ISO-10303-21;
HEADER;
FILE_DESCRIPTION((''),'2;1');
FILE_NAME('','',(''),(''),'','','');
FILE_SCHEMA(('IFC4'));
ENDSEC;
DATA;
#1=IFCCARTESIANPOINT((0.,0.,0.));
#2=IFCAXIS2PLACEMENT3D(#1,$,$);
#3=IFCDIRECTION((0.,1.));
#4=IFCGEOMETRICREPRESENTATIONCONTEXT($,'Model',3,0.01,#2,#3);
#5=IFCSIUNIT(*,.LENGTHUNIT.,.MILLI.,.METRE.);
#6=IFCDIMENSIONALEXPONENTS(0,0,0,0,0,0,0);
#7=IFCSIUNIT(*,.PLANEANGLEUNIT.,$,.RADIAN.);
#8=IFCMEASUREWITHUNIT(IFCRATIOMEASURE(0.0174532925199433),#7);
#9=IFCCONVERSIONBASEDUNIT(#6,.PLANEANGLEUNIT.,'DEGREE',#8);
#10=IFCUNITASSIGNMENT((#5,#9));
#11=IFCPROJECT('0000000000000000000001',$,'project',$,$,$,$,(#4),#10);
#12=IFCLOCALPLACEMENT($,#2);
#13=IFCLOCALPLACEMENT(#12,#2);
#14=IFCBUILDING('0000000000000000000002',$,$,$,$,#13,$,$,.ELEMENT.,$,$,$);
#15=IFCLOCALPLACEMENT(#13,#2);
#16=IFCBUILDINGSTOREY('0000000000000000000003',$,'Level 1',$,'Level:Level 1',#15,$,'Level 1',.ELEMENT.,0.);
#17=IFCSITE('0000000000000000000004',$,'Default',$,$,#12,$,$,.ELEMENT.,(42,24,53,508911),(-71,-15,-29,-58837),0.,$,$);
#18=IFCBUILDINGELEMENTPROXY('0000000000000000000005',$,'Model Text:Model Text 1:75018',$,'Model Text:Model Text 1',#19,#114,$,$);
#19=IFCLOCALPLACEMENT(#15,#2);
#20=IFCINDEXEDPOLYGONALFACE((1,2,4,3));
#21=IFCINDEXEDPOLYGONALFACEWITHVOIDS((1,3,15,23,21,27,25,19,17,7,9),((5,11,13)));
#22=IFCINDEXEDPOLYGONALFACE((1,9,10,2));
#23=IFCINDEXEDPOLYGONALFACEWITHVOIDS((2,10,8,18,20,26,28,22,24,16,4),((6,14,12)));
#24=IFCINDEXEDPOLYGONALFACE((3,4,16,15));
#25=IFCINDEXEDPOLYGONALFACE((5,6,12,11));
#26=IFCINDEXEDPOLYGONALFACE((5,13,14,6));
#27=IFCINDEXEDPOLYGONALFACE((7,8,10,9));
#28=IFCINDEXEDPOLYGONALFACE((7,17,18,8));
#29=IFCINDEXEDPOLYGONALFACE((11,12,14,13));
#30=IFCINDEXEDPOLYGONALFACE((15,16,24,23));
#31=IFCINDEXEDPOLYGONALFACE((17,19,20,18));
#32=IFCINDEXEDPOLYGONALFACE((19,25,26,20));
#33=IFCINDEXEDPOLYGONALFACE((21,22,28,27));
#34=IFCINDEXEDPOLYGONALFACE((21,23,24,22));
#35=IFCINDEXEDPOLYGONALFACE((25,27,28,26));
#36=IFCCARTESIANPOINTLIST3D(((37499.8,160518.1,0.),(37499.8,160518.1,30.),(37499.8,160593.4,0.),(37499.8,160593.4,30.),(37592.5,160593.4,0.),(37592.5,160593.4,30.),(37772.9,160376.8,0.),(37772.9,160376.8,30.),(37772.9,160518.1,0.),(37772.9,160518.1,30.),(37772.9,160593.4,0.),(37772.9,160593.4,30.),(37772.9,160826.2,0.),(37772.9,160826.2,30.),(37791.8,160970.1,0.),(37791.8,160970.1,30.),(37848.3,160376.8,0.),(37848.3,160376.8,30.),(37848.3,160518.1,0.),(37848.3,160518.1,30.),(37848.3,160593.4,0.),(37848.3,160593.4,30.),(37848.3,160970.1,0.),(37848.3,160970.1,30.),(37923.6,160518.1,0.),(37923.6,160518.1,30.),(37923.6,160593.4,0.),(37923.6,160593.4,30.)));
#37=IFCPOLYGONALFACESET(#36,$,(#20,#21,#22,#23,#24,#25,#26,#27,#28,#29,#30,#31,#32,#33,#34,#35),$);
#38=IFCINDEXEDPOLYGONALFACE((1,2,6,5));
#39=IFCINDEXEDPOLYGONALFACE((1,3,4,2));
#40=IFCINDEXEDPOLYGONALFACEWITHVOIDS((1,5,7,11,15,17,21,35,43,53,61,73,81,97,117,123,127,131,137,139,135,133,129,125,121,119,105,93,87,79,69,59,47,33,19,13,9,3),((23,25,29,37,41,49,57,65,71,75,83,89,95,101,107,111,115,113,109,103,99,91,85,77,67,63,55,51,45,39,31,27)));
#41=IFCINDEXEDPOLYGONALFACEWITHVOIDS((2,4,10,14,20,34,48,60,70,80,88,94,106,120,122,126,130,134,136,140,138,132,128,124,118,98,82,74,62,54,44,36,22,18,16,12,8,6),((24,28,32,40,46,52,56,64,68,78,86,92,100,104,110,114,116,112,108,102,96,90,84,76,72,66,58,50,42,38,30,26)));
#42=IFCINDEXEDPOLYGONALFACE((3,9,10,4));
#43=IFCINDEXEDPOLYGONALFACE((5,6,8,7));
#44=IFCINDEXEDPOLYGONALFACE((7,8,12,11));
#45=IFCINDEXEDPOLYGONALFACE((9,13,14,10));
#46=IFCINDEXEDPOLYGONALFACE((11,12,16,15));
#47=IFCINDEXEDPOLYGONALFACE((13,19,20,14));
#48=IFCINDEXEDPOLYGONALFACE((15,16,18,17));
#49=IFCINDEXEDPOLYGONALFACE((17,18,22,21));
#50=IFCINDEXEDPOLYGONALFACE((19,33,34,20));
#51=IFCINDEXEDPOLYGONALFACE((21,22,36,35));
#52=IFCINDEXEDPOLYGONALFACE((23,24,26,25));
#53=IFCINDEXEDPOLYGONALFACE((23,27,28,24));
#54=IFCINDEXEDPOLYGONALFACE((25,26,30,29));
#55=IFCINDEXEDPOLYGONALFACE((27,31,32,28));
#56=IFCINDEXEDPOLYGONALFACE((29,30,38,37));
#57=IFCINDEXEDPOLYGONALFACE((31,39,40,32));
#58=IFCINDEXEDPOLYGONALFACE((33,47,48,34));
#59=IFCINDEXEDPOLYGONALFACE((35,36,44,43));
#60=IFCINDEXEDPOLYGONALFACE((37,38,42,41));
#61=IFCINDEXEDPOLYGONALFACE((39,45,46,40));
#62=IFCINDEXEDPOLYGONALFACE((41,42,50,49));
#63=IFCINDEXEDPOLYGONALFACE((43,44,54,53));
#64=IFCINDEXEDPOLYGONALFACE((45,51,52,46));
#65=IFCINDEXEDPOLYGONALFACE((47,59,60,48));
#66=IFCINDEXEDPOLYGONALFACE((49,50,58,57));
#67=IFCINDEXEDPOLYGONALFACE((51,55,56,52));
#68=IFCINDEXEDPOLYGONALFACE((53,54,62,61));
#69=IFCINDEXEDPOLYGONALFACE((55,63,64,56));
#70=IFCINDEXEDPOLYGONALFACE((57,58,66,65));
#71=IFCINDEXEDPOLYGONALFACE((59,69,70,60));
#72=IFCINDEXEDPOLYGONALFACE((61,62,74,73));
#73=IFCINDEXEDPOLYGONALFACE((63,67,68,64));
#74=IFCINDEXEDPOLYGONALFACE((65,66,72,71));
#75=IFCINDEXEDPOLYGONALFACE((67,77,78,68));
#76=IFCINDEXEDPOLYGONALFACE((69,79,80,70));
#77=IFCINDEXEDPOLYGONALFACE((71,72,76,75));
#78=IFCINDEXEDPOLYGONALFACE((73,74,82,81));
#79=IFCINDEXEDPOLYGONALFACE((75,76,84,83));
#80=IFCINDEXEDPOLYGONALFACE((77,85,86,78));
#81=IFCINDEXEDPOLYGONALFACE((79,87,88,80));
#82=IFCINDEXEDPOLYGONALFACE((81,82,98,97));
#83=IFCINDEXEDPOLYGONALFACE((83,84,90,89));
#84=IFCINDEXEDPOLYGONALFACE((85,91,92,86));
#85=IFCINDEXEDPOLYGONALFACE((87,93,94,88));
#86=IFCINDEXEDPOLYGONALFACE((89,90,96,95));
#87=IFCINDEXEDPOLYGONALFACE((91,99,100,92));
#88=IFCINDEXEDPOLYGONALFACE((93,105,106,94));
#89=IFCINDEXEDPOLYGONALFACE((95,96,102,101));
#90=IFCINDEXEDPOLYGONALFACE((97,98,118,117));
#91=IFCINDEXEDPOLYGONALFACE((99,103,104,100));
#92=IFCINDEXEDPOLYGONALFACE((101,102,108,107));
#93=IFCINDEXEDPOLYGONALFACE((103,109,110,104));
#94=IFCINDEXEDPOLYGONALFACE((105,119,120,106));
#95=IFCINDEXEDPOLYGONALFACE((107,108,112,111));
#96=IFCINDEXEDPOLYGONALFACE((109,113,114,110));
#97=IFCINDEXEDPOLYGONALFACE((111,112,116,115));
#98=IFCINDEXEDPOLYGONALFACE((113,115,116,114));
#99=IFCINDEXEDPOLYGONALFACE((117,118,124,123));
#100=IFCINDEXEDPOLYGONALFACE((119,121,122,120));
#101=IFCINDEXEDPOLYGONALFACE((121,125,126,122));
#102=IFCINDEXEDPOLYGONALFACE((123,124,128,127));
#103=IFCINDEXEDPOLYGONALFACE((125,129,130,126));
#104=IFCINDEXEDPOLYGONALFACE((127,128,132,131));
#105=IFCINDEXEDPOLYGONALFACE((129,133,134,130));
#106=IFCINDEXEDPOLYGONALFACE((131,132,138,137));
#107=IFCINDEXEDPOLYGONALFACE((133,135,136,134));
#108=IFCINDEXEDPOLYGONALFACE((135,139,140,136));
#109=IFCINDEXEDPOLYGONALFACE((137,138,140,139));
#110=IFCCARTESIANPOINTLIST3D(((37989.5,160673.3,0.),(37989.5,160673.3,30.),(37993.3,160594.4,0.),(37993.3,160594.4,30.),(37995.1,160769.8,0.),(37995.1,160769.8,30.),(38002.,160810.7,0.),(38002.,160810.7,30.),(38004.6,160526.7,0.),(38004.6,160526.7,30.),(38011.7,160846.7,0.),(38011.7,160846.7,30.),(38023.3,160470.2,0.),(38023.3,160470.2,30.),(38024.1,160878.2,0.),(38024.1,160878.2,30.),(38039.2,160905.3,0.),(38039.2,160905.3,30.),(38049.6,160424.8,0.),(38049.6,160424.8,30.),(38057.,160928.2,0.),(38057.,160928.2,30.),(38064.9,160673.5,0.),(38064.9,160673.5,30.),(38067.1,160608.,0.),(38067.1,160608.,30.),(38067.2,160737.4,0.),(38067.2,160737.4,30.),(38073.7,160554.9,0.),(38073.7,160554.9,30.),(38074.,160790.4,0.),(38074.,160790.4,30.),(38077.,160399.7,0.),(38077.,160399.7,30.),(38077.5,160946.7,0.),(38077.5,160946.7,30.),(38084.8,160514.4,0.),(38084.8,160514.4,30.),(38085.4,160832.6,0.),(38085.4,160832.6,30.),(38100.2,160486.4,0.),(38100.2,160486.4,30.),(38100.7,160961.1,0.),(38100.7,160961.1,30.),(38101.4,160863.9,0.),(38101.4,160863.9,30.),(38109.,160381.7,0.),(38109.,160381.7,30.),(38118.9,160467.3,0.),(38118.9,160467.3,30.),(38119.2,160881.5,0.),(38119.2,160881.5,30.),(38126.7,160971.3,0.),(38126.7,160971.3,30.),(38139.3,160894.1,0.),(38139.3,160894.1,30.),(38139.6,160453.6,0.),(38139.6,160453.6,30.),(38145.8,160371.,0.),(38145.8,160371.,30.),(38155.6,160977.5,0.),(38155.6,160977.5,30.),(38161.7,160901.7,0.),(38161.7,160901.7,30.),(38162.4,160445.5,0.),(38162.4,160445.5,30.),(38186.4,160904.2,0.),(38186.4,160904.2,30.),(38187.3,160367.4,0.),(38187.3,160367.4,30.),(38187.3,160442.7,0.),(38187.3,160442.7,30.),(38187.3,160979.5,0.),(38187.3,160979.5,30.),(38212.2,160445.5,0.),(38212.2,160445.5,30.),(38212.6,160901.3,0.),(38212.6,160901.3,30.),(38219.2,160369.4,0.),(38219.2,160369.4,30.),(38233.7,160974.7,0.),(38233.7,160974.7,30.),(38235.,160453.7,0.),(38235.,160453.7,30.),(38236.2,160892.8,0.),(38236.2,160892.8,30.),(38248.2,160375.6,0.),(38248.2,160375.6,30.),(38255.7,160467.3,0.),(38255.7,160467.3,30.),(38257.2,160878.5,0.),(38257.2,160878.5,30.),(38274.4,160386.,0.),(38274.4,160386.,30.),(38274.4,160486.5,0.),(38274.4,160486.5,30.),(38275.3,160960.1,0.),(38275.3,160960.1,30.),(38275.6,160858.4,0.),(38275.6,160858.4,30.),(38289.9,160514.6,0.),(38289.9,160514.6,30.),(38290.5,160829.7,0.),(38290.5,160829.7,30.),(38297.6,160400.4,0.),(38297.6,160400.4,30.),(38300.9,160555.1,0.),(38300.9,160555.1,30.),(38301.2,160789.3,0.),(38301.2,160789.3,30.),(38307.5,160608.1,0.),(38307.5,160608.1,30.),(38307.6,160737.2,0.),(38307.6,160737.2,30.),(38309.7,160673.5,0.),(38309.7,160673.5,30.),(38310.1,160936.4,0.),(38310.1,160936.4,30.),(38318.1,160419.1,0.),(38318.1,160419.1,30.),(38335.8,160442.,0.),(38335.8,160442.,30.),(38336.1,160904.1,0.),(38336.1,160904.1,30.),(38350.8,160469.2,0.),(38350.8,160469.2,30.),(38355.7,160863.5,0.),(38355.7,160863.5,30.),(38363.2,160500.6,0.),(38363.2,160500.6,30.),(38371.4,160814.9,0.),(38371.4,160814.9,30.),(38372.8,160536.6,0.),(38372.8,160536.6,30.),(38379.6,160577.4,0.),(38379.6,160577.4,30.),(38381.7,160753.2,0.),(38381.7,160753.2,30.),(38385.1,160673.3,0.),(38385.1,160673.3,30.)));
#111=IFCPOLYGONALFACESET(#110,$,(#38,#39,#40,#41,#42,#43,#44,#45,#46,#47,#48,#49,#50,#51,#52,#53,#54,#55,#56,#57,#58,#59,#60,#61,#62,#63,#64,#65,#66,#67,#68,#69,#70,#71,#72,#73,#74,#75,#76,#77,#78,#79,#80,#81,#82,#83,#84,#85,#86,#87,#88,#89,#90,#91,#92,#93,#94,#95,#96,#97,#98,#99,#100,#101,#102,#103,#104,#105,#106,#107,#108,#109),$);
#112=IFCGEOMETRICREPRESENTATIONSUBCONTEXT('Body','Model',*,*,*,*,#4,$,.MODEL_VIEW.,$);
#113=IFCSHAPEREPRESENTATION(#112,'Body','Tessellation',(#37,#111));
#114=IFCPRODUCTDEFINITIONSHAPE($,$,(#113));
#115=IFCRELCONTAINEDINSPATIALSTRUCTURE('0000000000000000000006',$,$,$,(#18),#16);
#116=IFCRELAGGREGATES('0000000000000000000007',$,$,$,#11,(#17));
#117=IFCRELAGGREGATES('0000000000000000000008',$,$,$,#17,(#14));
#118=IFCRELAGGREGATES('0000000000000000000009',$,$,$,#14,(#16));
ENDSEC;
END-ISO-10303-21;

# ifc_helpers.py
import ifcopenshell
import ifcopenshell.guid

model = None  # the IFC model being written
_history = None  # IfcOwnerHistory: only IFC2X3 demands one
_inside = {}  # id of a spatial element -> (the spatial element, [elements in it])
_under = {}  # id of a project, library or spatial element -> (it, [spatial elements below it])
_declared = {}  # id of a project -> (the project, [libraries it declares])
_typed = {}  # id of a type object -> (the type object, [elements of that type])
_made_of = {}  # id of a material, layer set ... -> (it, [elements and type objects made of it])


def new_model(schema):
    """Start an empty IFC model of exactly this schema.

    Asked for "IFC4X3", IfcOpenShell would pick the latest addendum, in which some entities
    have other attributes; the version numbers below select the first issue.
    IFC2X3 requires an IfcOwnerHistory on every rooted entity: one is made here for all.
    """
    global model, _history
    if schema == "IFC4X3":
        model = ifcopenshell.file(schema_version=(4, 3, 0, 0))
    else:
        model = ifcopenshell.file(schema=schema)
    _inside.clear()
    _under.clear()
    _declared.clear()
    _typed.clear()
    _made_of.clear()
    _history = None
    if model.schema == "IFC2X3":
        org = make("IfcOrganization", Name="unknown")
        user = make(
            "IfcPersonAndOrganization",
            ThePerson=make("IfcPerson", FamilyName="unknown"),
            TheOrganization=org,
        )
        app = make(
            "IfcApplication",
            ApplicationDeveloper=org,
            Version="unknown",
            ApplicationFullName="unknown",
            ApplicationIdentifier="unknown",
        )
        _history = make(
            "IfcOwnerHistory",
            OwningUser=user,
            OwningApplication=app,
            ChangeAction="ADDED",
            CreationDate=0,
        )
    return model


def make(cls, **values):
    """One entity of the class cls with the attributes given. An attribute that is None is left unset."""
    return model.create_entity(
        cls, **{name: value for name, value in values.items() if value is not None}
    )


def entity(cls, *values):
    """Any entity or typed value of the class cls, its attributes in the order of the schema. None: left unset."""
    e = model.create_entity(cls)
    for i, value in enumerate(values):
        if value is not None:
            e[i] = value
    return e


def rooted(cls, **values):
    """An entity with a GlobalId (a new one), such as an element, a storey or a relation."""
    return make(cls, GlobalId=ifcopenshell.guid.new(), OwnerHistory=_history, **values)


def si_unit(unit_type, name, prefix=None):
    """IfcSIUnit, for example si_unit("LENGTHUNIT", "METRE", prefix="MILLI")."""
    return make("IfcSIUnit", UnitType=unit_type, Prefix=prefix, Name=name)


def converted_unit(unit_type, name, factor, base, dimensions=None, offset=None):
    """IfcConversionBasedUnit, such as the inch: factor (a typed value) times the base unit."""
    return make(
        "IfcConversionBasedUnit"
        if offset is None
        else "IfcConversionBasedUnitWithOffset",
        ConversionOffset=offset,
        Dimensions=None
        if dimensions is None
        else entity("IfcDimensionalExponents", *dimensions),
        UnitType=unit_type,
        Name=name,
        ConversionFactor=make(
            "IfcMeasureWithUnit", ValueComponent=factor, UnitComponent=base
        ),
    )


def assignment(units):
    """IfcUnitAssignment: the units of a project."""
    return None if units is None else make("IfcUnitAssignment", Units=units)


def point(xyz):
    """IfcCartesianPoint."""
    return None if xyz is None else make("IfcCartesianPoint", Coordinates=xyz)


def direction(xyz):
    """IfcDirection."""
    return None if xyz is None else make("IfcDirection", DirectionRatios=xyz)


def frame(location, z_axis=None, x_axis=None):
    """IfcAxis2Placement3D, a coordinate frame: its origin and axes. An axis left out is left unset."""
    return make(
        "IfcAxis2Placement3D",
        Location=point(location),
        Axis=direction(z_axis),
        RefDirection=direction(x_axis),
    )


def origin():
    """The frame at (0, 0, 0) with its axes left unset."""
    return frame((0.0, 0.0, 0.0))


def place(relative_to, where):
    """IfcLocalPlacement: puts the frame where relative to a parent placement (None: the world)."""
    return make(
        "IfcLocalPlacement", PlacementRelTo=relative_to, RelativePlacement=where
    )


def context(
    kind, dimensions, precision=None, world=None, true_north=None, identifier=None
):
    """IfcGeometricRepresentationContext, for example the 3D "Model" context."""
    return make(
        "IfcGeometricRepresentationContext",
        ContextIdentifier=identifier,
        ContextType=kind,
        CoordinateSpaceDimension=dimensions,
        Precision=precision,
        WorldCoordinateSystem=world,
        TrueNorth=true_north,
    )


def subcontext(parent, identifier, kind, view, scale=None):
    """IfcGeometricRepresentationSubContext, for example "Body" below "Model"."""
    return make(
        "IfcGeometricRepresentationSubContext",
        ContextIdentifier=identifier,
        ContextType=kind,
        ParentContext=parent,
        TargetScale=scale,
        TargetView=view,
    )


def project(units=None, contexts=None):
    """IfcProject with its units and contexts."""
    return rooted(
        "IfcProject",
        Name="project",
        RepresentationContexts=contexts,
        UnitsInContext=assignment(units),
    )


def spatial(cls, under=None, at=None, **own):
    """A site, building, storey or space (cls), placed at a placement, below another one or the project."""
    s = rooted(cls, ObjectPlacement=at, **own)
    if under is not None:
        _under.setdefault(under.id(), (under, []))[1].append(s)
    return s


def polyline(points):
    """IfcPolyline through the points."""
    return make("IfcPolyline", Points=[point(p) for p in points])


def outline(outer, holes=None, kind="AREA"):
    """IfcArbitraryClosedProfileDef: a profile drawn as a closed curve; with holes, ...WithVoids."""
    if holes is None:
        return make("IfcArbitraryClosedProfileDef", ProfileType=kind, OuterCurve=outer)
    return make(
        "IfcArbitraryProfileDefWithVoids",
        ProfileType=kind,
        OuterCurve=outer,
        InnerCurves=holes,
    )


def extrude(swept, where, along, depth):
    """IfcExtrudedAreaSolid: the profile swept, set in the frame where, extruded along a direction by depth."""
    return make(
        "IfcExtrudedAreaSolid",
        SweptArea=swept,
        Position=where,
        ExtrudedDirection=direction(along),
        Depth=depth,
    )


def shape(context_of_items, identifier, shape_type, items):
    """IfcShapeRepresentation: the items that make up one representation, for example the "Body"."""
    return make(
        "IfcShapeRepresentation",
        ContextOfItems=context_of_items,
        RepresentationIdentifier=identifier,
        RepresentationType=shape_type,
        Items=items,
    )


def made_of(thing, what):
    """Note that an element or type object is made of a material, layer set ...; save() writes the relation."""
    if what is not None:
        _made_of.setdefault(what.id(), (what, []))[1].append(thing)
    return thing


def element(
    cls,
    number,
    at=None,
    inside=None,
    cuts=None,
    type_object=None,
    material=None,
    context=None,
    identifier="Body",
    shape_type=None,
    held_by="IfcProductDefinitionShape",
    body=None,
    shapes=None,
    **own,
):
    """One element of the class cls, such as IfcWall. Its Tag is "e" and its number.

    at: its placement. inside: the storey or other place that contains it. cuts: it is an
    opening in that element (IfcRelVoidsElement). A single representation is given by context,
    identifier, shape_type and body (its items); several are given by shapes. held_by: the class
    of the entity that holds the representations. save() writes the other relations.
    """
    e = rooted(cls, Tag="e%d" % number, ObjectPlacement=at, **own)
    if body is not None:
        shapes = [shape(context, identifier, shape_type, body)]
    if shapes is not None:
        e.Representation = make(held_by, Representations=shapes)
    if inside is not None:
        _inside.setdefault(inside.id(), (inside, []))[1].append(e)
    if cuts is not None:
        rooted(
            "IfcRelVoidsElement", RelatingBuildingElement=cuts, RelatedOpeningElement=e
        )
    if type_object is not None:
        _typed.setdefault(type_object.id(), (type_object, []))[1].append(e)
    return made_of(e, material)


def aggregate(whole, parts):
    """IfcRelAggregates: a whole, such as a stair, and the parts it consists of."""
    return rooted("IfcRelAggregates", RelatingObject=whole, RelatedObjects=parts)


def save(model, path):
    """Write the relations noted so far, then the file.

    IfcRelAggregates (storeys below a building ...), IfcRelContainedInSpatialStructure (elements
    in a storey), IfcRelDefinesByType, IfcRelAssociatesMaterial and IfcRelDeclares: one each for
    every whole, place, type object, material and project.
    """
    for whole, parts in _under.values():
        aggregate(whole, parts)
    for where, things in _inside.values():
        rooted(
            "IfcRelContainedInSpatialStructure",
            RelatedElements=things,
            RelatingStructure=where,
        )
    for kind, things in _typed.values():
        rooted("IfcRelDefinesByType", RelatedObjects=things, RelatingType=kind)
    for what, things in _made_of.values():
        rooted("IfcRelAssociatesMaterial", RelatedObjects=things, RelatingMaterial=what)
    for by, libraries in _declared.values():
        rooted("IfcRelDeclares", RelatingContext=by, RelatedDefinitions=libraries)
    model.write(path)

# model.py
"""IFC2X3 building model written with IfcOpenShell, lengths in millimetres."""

from ifc_helpers import new_model, entity, si_unit, converted_unit, direction, frame, origin, place, context, subcontext, project, spatial, polyline, outline, extrude, element, save


model = new_model("IFC2X3")

# Units and contexts
model_context = context("Model", 3, precision=0.01, world=origin(), true_north=direction((0.0, 1.0)))
body_context = subcontext(model_context, "Body", "Model", "MODEL_VIEW")
ifc_project = project(units=[si_unit("LENGTHUNIT", "METRE", prefix="MILLI"), converted_unit("PLANEANGLEUNIT", "DEGREE", entity("IfcRatioMeasure", 0.0174532925199433), si_unit("PLANEANGLEUNIT", "RADIAN"), dimensions=[0, 0, 0, 0, 0, 0, 0])], contexts=[model_context])

# Site, building, storey
site_placement = place(None, origin())
site = spatial("IfcSite", under=ifc_project, at=site_placement, Name="Default", CompositionType="ELEMENT", RefLatitude=(42, 24, 53, 508911), RefLongitude=(-71, -15, -29, -58837), RefElevation=0.0)
building_placement = place(site_placement, origin())
building = spatial("IfcBuilding", under=site, at=building_placement, CompositionType="ELEMENT")
storey_placement = place(building_placement, origin())
storey = spatial("IfcBuildingStorey", under=building, at=storey_placement, Name="Level 1", ObjectType="Level:Level 1", LongName="Level 1", CompositionType="ELEMENT", Elevation=0.0)

# Building element proxy
proxy_1_placement = place(storey_placement, origin())
element("IfcBuildingElementProxy", 1, at=proxy_1_placement, inside=storey, Name="Model Text:Model Text 1:75018", ObjectType="Model Text:Model Text 1", context=body_context, shape_type="SweptSolid", body=[
    extrude(outline(polyline([(-6.8, -218.3), (68.5, -218.3), (68.5, -77.1), (143.8, -77.1), (143.8, -1.7), (68.5, -1.7), (68.5, 375.0), (12.0, 375.0), (-280.0, -1.7), (-280.0, -77.1), (-6.8, -77.1), (-6.8, -218.3)]), holes=[polyline([(-6.8, -1.7), (-187.3, -1.7), (-6.8, 231.1), (-6.8, -1.7)])]), frame((37779.8, 160595.1, 0.0)), (0.0, 0.0, 1.0), 30.0),
    extrude(outline(polyline([(-10.6, -198.7), (68.3, -198.7), (136.5, -190.7), (193.9, -174.7), (240.5, -150.6), (266.9, -124.4), (286.3, -93.2), (298.8, -57.0), (304.3, -15.7), (303.8, 16.2), (299.0, 45.5), (289.9, 72.1), (276.6, 96.0), (258.9, 117.3), (236.9, 136.2), (210.4, 152.5), (179.6, 166.3), (144.1, 177.6), (103.7, 186.3), (8.2, 196.4), (-71.8, 196.7), (-134.0, 189.4), (-183.3, 176.1), (-224.7, 158.4), (-258.2, 133.9), (-283.5, 100.3), (-300.1, 59.5), (-307.1, 13.4), (-306.6, -18.4), (-301.8, -47.5), (-292.8, -74.0), (-279.6, -97.9), (-262.0, -119.2), (-240.0, -138.1), (-213.6, -154.5), (-182.8, -168.4), (-147.3, -179.8), (-106.7, -188.6), (-10.6, -198.7)]), holes=[polyline([(-7.2, -123.5), (-71.0, -118.2), (-123.6, -108.8), (-165.2, -95.4), (-195.7, -78.0), (-212.4, -59.4), (-224.1, -38.7), (-230.6, -15.9), (-231.9, 8.9), (-227.8, 35.0), (-218.1, 58.1), (-202.8, 78.4), (-182.0, 95.8), (-152.6, 109.4), (-111.7, 118.1), (-59.4, 122.0), (4.4, 121.1), (69.6, 115.8), (122.2, 106.7), (162.2, 93.7), (189.5, 77.0), (207.7, 57.4), (220.4, 36.0), (227.5, 12.8), (229.1, -12.1), (225.2, -36.8), (215.9, -59.2), (201.3, -79.3), (181.4, -97.1), (152.6, -111.2), (111.6, -120.3), (58.3, -124.4), (-7.2, -123.5)])]), frame((38188.6, 160672.1, 0.0), z_axis=(0.0, 0.0, 1.0), x_axis=(0.047515, -0.998871, 0.0)), (0.0, 0.0, 1.0), 30.0),
])

save(model, "model.ifc")
